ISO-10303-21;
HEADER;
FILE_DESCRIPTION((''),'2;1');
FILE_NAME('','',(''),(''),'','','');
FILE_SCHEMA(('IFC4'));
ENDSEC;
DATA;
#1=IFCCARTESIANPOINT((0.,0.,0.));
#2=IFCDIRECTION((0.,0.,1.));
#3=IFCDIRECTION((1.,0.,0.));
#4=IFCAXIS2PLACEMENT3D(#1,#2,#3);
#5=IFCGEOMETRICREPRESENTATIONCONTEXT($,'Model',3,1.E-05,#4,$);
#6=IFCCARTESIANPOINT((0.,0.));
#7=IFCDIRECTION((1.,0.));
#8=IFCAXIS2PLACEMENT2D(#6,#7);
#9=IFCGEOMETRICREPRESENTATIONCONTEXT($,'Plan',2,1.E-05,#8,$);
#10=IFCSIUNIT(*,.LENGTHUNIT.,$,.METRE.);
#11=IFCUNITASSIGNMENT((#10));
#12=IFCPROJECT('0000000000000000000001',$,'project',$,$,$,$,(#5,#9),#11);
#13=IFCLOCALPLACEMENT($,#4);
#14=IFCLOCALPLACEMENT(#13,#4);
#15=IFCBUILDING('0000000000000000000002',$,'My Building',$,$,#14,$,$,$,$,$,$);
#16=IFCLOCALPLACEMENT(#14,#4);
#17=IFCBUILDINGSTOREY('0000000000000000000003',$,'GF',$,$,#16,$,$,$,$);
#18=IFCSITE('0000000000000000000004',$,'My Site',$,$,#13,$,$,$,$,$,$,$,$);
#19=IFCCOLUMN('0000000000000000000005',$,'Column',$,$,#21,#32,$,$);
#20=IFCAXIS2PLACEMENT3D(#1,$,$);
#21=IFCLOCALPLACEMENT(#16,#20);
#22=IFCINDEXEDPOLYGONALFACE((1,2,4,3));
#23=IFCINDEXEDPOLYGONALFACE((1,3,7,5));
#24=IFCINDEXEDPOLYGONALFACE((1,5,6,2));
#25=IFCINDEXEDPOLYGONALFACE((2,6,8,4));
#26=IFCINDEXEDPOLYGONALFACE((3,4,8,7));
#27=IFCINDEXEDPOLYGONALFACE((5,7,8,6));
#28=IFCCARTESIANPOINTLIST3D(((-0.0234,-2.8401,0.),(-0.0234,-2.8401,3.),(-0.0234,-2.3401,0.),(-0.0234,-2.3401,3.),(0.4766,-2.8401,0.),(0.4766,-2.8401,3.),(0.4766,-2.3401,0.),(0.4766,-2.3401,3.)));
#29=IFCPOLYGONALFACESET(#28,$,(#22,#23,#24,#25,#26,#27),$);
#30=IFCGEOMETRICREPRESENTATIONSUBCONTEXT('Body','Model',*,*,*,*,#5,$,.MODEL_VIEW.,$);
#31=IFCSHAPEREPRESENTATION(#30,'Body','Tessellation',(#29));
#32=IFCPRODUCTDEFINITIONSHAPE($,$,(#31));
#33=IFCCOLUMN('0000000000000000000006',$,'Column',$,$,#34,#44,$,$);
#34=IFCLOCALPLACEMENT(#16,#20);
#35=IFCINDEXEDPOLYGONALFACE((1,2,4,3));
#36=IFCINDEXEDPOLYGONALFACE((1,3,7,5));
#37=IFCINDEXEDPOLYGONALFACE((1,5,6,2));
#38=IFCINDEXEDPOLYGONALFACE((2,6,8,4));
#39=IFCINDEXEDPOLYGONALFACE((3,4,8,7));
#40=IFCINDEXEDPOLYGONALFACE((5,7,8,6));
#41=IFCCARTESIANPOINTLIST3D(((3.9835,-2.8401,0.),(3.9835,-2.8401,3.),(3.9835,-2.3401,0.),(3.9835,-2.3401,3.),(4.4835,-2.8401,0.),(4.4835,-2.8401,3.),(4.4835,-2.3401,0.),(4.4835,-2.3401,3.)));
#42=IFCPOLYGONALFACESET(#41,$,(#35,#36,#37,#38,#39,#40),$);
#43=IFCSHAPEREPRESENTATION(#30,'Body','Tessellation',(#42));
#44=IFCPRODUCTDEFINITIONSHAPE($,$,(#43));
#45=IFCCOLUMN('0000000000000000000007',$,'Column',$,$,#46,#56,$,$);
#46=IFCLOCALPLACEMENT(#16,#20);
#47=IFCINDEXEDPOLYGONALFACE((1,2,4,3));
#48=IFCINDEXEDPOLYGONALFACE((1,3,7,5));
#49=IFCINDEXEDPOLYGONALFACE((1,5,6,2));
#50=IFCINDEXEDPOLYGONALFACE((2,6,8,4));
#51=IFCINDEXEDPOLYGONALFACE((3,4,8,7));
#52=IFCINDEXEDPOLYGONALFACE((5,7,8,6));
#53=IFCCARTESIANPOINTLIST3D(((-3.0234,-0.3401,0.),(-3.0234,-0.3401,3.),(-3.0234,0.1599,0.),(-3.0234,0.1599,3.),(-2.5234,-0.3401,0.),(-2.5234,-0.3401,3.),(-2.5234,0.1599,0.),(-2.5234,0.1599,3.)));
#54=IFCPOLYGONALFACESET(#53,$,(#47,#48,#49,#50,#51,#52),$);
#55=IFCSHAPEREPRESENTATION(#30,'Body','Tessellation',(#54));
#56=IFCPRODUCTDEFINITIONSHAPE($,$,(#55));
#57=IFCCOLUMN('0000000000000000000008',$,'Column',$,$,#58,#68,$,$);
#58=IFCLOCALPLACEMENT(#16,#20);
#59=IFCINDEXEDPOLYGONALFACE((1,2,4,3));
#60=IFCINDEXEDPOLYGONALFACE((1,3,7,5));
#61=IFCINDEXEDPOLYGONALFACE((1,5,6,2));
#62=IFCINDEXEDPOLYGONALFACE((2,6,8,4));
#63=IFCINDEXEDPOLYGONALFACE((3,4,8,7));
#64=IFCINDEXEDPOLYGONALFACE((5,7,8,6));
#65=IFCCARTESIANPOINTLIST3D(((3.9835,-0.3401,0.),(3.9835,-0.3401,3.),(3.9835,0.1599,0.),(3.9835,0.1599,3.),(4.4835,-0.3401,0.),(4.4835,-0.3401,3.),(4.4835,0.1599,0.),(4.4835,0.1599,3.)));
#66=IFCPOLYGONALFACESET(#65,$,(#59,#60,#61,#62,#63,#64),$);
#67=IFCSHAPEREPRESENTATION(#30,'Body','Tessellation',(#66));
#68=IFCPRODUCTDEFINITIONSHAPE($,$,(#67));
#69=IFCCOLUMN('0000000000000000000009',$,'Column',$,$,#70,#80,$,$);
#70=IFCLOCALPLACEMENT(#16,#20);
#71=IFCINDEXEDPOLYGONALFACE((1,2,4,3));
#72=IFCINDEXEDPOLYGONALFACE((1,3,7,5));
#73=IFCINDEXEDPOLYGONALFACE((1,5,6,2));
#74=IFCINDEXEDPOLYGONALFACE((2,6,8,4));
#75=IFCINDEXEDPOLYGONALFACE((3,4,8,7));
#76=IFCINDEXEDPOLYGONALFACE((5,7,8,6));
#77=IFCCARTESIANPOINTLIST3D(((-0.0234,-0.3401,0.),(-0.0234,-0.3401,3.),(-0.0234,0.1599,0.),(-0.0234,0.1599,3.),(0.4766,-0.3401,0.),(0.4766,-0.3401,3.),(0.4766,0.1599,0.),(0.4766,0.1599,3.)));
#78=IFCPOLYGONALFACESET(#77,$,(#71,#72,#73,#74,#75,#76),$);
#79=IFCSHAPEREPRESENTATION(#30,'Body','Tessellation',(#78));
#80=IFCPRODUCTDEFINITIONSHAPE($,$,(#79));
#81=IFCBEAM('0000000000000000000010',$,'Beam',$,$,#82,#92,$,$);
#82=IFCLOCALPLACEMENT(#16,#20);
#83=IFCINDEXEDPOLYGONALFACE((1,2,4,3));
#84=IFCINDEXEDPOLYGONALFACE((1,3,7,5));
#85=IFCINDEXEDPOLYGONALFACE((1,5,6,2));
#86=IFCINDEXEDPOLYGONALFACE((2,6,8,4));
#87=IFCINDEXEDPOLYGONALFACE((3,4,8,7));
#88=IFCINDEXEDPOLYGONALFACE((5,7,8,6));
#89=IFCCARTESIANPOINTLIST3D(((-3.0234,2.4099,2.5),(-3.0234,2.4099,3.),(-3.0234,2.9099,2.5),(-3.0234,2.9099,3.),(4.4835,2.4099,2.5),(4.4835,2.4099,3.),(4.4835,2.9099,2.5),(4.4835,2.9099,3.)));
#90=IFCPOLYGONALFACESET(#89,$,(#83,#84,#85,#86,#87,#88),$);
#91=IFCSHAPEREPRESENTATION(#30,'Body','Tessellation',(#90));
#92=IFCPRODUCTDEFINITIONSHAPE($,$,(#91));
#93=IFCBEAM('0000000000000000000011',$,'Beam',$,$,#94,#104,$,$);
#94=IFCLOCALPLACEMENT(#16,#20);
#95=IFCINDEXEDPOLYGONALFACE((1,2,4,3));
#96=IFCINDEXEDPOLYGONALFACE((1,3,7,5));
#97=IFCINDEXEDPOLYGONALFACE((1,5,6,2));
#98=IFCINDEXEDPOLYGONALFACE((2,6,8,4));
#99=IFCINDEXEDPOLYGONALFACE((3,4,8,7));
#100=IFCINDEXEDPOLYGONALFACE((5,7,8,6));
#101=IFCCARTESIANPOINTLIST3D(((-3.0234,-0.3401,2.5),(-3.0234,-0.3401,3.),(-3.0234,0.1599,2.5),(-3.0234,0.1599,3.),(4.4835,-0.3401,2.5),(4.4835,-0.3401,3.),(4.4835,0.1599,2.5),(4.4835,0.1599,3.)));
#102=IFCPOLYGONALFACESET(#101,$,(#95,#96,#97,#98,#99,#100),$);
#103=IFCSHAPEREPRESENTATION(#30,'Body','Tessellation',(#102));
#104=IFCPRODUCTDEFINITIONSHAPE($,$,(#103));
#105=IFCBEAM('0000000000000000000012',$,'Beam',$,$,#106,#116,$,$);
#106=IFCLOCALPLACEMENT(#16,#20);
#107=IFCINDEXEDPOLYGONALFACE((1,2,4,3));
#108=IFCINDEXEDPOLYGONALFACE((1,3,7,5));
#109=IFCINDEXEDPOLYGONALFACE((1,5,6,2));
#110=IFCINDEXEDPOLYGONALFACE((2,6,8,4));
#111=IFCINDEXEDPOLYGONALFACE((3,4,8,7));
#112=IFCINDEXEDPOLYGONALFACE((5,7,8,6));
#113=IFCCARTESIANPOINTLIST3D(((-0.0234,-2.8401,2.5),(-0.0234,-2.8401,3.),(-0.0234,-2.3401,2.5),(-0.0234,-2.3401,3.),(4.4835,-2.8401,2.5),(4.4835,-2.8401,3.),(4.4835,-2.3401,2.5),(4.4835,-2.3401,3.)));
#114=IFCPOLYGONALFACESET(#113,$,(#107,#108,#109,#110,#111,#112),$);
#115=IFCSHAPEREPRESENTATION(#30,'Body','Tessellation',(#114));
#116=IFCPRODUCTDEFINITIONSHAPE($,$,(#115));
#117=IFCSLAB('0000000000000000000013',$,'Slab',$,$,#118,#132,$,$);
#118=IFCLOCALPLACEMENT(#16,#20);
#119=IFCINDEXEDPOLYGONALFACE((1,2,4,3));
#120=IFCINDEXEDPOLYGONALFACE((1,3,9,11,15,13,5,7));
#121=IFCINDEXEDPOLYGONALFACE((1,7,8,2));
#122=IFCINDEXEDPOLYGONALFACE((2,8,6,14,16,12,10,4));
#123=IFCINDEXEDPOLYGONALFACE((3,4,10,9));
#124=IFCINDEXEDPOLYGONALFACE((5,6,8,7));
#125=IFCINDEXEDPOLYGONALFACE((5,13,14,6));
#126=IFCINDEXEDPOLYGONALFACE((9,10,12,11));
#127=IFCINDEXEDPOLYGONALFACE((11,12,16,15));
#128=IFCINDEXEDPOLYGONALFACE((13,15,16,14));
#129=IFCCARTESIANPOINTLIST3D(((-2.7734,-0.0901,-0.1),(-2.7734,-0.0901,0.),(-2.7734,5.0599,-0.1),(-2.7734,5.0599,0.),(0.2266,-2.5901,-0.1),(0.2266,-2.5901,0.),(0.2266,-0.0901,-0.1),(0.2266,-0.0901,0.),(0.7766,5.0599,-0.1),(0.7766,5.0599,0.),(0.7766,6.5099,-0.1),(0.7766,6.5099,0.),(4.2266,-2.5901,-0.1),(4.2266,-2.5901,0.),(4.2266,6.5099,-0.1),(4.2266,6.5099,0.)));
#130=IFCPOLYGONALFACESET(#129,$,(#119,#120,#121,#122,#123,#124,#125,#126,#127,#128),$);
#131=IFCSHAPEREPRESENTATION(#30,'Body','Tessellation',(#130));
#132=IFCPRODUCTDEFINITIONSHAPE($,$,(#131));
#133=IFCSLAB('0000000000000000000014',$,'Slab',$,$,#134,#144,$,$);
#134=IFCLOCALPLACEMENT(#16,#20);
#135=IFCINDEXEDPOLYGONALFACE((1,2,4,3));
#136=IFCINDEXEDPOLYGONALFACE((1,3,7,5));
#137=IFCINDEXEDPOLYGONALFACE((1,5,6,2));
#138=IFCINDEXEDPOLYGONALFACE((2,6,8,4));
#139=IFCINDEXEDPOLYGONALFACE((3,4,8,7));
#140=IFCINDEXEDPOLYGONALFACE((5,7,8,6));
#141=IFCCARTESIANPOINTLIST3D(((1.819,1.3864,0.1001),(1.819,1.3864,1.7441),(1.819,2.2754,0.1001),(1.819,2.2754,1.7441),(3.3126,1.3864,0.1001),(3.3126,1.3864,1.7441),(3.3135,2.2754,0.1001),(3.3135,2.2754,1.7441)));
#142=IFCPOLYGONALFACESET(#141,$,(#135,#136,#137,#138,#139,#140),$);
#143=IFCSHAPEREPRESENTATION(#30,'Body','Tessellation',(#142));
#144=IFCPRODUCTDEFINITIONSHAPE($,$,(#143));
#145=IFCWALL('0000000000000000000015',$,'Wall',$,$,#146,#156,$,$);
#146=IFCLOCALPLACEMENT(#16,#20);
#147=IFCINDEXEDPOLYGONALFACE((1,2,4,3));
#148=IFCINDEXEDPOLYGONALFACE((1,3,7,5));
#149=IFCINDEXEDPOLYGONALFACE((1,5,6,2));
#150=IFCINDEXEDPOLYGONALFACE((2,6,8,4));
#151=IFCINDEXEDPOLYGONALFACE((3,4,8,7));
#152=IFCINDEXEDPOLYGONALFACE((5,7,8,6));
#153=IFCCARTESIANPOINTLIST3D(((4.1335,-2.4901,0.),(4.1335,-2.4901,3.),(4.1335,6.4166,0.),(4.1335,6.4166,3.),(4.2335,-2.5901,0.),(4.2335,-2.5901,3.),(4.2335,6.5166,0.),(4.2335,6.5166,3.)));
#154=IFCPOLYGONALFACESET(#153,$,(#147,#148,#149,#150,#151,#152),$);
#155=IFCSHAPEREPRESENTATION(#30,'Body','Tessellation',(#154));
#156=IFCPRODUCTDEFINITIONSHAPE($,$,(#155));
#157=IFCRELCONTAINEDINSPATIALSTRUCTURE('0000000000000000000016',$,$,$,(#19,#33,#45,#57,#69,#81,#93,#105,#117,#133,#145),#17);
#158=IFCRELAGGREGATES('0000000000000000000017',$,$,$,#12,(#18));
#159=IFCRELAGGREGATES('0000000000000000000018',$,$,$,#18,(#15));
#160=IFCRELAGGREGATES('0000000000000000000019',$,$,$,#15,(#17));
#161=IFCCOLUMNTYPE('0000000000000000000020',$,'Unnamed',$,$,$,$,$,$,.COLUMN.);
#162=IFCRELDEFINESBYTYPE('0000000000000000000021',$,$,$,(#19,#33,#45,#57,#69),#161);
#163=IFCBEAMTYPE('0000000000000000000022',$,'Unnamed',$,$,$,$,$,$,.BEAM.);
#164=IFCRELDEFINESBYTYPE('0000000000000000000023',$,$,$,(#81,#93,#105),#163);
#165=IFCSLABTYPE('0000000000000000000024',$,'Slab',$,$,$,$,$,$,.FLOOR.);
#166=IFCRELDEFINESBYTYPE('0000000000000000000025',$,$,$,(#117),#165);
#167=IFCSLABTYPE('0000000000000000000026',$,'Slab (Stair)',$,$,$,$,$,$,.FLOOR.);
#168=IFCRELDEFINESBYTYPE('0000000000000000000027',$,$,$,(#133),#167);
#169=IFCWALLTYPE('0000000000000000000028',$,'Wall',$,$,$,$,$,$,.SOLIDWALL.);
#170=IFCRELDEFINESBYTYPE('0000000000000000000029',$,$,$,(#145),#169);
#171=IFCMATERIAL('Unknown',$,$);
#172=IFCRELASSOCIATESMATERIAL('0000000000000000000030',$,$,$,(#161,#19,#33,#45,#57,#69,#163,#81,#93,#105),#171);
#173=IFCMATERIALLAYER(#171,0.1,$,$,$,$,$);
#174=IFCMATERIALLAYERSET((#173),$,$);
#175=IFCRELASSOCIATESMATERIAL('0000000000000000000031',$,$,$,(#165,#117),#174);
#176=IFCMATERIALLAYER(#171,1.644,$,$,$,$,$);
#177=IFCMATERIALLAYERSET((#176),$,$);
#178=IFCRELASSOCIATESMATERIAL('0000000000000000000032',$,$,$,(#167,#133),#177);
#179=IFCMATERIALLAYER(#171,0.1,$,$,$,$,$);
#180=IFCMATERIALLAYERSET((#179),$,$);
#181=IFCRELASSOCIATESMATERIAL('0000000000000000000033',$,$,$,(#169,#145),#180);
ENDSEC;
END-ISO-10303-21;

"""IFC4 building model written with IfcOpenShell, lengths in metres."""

from ifc_helpers import new_model, si_unit, frame, origin_with_axes, origin_2d_with_axis, place, context, subcontext, project, spatial, line, indexed_curve, rectangle, outline, extrude, material, layer, layer_set, layer_usage, material_profile, profile_set, profile_usage, type_object, element, save


model = new_model("IFC4")

# Units and contexts
model_context = context("Model", 3, precision=1e-05, world=origin_with_axes())
plan_context = context("Plan", 2, precision=1e-05, world=origin_2d_with_axis())
body_context_1 = subcontext(model_context, "Body", "Model", "MODEL_VIEW")
ifc_project = project(units=[si_unit("LENGTHUNIT", "METRE")], contexts=[model_context, plan_context])

# Site, building, storey
site_placement = place(None, origin_with_axes())
site = spatial("IfcSite", under=ifc_project, at=site_placement, Name="My Site")
building_placement = place(site_placement, origin_with_axes())
building = spatial("IfcBuilding", under=site, at=building_placement, Name="My Building")
storey_placement = place(building_placement, origin_with_axes())
storey = spatial("IfcBuildingStorey", under=building, at=storey_placement, Name="GF")

# Columns
ifc_material = material(Name="Unknown")
ifc_material_profile_1 = material_profile(ifc_material, rectangle(XDim=0.5, YDim=0.5))
ifc_profile_set_1 = profile_set([ifc_material_profile_1])
ifc_profile_usage_1 = profile_usage(ifc_profile_set_1, cardinal=5)
column_type = type_object("IfcColumnType", Name="Unnamed", PredefinedType="COLUMN", material=ifc_profile_set_1)
column_1_placement = place(storey_placement, frame((0.2266, -2.5901, 0.0), z_axis=(0.0, 0.0, 1.0), x_axis=(1.0, 0.0, 0.0)))
element("IfcColumn", 1, at=column_1_placement, inside=storey, type_object=column_type, material=ifc_profile_usage_1, Name="Column", context=body_context_1, shape_type="SweptSolid", body=[
    extrude(rectangle(XDim=0.5, YDim=0.5), origin_with_axes(), (0.0, 0.0, 1.0), 3.0),
])
ifc_profile_usage_2 = profile_usage(ifc_profile_set_1, cardinal=5)
column_2_placement = place(storey_placement, frame((4.2335, -2.5901, 0.0), z_axis=(0.0, 0.0, 1.0), x_axis=(1.0, 0.0, 0.0)))
element("IfcColumn", 2, at=column_2_placement, inside=storey, type_object=column_type, material=ifc_profile_usage_2, Name="Column", context=body_context_1, shape_type="SweptSolid", body=[
    extrude(rectangle(XDim=0.5, YDim=0.5), origin_with_axes(), (0.0, 0.0, 1.0), 3.0),
])
ifc_profile_usage_3 = profile_usage(ifc_profile_set_1, cardinal=5)
column_3_placement = place(storey_placement, frame((-2.7734, -0.0901, 0.0), z_axis=(0.0, 0.0, 1.0), x_axis=(1.0, 0.0, 0.0)))
element("IfcColumn", 3, at=column_3_placement, inside=storey, type_object=column_type, material=ifc_profile_usage_3, Name="Column", context=body_context_1, shape_type="SweptSolid", body=[
    extrude(rectangle(XDim=0.5, YDim=0.5), origin_with_axes(), (0.0, 0.0, 1.0), 3.0),
])
ifc_profile_usage_4 = profile_usage(ifc_profile_set_1, cardinal=5)
column_4_placement = place(storey_placement, frame((4.2335, -0.0901, 0.0), z_axis=(0.0, 0.0, 1.0), x_axis=(1.0, 0.0, 0.0)))
element("IfcColumn", 4, at=column_4_placement, inside=storey, type_object=column_type, material=ifc_profile_usage_4, Name="Column", context=body_context_1, shape_type="SweptSolid", body=[
    extrude(rectangle(XDim=0.5, YDim=0.5), origin_with_axes(), (0.0, 0.0, 1.0), 3.0),
])
ifc_profile_usage_5 = profile_usage(ifc_profile_set_1, cardinal=5)
column_5_placement = place(storey_placement, frame((0.2266, -0.0901, 0.0), z_axis=(0.0, 0.0, 1.0), x_axis=(1.0, 0.0, 0.0)))
element("IfcColumn", 5, at=column_5_placement, inside=storey, type_object=column_type, material=ifc_profile_usage_5, Name="Column", context=body_context_1, shape_type="SweptSolid", body=[
    extrude(rectangle(XDim=0.5, YDim=0.5), origin_with_axes(), (0.0, 0.0, 1.0), 3.0),
])

# Beams
ifc_material_profile_2 = material_profile(ifc_material, rectangle(XDim=0.5, YDim=0.5))
ifc_profile_set_2 = profile_set([ifc_material_profile_2])
ifc_profile_usage_6 = profile_usage(ifc_profile_set_2, cardinal=7)
beam_type = type_object("IfcBeamType", Name="Unnamed", PredefinedType="BEAM", material=ifc_profile_set_2)
beam_1_placement = place(storey_placement, frame((4.4835, 2.4099, 3.0), z_axis=(-1.0, 0.0, 0.0), x_axis=(0.0, -1.0, 0.0)))
element("IfcBeam", 6, at=beam_1_placement, inside=storey, type_object=beam_type, material=ifc_profile_usage_6, Name="Beam", context=body_context_1, shape_type="SweptSolid", body=[
    extrude(rectangle(XDim=0.5, YDim=0.5), frame((-0.25, -0.25, 0.0), z_axis=(0.0, 0.0, 1.0), x_axis=(1.0, 0.0, 0.0)), (0.0, 0.0, 1.0), 7.5069),
])
ifc_profile_usage_7 = profile_usage(ifc_profile_set_2, cardinal=7)
beam_2_placement = place(storey_placement, frame((4.4835, -0.3401, 3.0), z_axis=(-1.0, 0.0, 0.0), x_axis=(0.0, -1.0, 0.0)))
element("IfcBeam", 7, at=beam_2_placement, inside=storey, type_object=beam_type, material=ifc_profile_usage_7, Name="Beam", context=body_context_1, shape_type="SweptSolid", body=[
    extrude(rectangle(XDim=0.5, YDim=0.5), frame((-0.25, -0.25, 0.0), z_axis=(0.0, 0.0, 1.0), x_axis=(1.0, 0.0, 0.0)), (0.0, 0.0, 1.0), 7.5069),
])
ifc_profile_usage_8 = profile_usage(ifc_profile_set_2, cardinal=7)
beam_3_placement = place(storey_placement, frame((-0.0234, -2.3401, 3.0), z_axis=(1.0, 0.0, 0.0), x_axis=(0.0, 1.0, 0.0)))
element("IfcBeam", 8, at=beam_3_placement, inside=storey, type_object=beam_type, material=ifc_profile_usage_8, Name="Beam", context=body_context_1, shape_type="SweptSolid", body=[
    extrude(rectangle(XDim=0.5, YDim=0.5), frame((-0.25, -0.25, 0.0), z_axis=(0.0, 0.0, 1.0), x_axis=(1.0, 0.0, 0.0)), (0.0, 0.0, 1.0), 4.5069),
])

# Slabs
ifc_layer_1 = layer(ifc_material, 0.1)
ifc_layer_set_1 = layer_set([ifc_layer_1])
ifc_layer_usage_1 = layer_usage(ifc_layer_set_1, "AXIS3", "POSITIVE", -0.1)
slab_type_1 = type_object("IfcSlabType", Name="Slab", PredefinedType="FLOOR", material=ifc_layer_set_1)
slab_1_placement = place(storey_placement, frame((4.2266, -2.5901, 0.0), z_axis=(0.0, 0.0, 1.0), x_axis=(1.0, 0.0, 0.0)))
element("IfcSlab", 9, at=slab_1_placement, inside=storey, type_object=slab_type_1, material=ifc_layer_usage_1, Name="Slab", context=body_context_1, shape_type="SweptSolid", body=[
    extrude(outline(indexed_curve([(0.0, 0.0), (0.0, 9.1), (-3.45, 9.1), (-3.45, 7.65), (-7.0, 7.65), (-7.0, 2.5), (-4.0, 2.5), (-4.0, 0.0), (0.0, 0.0)])), frame((0.0, 0.0, -0.1), z_axis=(0.0, 0.0, 1.0), x_axis=(1.0, 0.0, 0.0)), (0.0, 0.0, 1.0), 0.1),
])
ifc_layer_2 = layer(ifc_material, 1.644)
ifc_layer_set_2 = layer_set([ifc_layer_2])
ifc_layer_usage_2 = layer_usage(ifc_layer_set_2, "AXIS3", "POSITIVE", -0.1)
slab_type_2 = type_object("IfcSlabType", Name="Slab (Stair)", PredefinedType="FLOOR", material=ifc_layer_set_2)
slab_2_placement = place(storey_placement, frame((3.3126, 2.2754, 0.2001), z_axis=(0.0, 0.0, 1.0), x_axis=(1.0, 0.0, 0.0)))
element("IfcSlab", 10, at=slab_2_placement, inside=storey, type_object=slab_type_2, material=ifc_layer_usage_2, Name="Slab", context=body_context_1, shape_type="SweptSolid", body=[
    extrude(outline(indexed_curve([(-1.4936, 0.0), (-1.4936, -0.8889), (0.0, -0.8889), (0.0009, 0.0), (-1.4936, 0.0)])), frame((0.0, 0.0, -0.1), z_axis=(0.0, 0.0, 1.0), x_axis=(1.0, 0.0, 0.0)), (0.0, 0.0, 1.0), 1.644),
])

# Shared definitions
ifc_layer_3 = layer(ifc_material, 0.1)
ifc_layer_set_3 = layer_set([ifc_layer_3])
wall_type = type_object("IfcWallType", Name="Wall", PredefinedType="SOLIDWALL", material=ifc_layer_set_3)

# Wall
ifc_layer_usage_3 = layer_usage(ifc_layer_set_3, "AXIS2", "POSITIVE", 0.0)
wall_1_placement = place(storey_placement, frame((4.2335, -2.5901, 0.0), z_axis=(0.0, 0.0, 1.0), x_axis=(0.0, 1.0, 0.0)))
element("IfcWall", 11, at=wall_1_placement, inside=storey, type_object=wall_type, material=ifc_layer_usage_3, Name="Wall", context=body_context_1, shape_type="SweptSolid", body=[
    extrude(outline(indexed_curve([(0.0, 0.0), (0.1, 0.1), (9.0067, 0.1), (9.1067, 0.0)], segments=[line(1, 2, 3, 4, 1)])), origin_with_axes(), (0.0, 0.0, 1.0), 3.0),
])

save(model, "model.ifc")
